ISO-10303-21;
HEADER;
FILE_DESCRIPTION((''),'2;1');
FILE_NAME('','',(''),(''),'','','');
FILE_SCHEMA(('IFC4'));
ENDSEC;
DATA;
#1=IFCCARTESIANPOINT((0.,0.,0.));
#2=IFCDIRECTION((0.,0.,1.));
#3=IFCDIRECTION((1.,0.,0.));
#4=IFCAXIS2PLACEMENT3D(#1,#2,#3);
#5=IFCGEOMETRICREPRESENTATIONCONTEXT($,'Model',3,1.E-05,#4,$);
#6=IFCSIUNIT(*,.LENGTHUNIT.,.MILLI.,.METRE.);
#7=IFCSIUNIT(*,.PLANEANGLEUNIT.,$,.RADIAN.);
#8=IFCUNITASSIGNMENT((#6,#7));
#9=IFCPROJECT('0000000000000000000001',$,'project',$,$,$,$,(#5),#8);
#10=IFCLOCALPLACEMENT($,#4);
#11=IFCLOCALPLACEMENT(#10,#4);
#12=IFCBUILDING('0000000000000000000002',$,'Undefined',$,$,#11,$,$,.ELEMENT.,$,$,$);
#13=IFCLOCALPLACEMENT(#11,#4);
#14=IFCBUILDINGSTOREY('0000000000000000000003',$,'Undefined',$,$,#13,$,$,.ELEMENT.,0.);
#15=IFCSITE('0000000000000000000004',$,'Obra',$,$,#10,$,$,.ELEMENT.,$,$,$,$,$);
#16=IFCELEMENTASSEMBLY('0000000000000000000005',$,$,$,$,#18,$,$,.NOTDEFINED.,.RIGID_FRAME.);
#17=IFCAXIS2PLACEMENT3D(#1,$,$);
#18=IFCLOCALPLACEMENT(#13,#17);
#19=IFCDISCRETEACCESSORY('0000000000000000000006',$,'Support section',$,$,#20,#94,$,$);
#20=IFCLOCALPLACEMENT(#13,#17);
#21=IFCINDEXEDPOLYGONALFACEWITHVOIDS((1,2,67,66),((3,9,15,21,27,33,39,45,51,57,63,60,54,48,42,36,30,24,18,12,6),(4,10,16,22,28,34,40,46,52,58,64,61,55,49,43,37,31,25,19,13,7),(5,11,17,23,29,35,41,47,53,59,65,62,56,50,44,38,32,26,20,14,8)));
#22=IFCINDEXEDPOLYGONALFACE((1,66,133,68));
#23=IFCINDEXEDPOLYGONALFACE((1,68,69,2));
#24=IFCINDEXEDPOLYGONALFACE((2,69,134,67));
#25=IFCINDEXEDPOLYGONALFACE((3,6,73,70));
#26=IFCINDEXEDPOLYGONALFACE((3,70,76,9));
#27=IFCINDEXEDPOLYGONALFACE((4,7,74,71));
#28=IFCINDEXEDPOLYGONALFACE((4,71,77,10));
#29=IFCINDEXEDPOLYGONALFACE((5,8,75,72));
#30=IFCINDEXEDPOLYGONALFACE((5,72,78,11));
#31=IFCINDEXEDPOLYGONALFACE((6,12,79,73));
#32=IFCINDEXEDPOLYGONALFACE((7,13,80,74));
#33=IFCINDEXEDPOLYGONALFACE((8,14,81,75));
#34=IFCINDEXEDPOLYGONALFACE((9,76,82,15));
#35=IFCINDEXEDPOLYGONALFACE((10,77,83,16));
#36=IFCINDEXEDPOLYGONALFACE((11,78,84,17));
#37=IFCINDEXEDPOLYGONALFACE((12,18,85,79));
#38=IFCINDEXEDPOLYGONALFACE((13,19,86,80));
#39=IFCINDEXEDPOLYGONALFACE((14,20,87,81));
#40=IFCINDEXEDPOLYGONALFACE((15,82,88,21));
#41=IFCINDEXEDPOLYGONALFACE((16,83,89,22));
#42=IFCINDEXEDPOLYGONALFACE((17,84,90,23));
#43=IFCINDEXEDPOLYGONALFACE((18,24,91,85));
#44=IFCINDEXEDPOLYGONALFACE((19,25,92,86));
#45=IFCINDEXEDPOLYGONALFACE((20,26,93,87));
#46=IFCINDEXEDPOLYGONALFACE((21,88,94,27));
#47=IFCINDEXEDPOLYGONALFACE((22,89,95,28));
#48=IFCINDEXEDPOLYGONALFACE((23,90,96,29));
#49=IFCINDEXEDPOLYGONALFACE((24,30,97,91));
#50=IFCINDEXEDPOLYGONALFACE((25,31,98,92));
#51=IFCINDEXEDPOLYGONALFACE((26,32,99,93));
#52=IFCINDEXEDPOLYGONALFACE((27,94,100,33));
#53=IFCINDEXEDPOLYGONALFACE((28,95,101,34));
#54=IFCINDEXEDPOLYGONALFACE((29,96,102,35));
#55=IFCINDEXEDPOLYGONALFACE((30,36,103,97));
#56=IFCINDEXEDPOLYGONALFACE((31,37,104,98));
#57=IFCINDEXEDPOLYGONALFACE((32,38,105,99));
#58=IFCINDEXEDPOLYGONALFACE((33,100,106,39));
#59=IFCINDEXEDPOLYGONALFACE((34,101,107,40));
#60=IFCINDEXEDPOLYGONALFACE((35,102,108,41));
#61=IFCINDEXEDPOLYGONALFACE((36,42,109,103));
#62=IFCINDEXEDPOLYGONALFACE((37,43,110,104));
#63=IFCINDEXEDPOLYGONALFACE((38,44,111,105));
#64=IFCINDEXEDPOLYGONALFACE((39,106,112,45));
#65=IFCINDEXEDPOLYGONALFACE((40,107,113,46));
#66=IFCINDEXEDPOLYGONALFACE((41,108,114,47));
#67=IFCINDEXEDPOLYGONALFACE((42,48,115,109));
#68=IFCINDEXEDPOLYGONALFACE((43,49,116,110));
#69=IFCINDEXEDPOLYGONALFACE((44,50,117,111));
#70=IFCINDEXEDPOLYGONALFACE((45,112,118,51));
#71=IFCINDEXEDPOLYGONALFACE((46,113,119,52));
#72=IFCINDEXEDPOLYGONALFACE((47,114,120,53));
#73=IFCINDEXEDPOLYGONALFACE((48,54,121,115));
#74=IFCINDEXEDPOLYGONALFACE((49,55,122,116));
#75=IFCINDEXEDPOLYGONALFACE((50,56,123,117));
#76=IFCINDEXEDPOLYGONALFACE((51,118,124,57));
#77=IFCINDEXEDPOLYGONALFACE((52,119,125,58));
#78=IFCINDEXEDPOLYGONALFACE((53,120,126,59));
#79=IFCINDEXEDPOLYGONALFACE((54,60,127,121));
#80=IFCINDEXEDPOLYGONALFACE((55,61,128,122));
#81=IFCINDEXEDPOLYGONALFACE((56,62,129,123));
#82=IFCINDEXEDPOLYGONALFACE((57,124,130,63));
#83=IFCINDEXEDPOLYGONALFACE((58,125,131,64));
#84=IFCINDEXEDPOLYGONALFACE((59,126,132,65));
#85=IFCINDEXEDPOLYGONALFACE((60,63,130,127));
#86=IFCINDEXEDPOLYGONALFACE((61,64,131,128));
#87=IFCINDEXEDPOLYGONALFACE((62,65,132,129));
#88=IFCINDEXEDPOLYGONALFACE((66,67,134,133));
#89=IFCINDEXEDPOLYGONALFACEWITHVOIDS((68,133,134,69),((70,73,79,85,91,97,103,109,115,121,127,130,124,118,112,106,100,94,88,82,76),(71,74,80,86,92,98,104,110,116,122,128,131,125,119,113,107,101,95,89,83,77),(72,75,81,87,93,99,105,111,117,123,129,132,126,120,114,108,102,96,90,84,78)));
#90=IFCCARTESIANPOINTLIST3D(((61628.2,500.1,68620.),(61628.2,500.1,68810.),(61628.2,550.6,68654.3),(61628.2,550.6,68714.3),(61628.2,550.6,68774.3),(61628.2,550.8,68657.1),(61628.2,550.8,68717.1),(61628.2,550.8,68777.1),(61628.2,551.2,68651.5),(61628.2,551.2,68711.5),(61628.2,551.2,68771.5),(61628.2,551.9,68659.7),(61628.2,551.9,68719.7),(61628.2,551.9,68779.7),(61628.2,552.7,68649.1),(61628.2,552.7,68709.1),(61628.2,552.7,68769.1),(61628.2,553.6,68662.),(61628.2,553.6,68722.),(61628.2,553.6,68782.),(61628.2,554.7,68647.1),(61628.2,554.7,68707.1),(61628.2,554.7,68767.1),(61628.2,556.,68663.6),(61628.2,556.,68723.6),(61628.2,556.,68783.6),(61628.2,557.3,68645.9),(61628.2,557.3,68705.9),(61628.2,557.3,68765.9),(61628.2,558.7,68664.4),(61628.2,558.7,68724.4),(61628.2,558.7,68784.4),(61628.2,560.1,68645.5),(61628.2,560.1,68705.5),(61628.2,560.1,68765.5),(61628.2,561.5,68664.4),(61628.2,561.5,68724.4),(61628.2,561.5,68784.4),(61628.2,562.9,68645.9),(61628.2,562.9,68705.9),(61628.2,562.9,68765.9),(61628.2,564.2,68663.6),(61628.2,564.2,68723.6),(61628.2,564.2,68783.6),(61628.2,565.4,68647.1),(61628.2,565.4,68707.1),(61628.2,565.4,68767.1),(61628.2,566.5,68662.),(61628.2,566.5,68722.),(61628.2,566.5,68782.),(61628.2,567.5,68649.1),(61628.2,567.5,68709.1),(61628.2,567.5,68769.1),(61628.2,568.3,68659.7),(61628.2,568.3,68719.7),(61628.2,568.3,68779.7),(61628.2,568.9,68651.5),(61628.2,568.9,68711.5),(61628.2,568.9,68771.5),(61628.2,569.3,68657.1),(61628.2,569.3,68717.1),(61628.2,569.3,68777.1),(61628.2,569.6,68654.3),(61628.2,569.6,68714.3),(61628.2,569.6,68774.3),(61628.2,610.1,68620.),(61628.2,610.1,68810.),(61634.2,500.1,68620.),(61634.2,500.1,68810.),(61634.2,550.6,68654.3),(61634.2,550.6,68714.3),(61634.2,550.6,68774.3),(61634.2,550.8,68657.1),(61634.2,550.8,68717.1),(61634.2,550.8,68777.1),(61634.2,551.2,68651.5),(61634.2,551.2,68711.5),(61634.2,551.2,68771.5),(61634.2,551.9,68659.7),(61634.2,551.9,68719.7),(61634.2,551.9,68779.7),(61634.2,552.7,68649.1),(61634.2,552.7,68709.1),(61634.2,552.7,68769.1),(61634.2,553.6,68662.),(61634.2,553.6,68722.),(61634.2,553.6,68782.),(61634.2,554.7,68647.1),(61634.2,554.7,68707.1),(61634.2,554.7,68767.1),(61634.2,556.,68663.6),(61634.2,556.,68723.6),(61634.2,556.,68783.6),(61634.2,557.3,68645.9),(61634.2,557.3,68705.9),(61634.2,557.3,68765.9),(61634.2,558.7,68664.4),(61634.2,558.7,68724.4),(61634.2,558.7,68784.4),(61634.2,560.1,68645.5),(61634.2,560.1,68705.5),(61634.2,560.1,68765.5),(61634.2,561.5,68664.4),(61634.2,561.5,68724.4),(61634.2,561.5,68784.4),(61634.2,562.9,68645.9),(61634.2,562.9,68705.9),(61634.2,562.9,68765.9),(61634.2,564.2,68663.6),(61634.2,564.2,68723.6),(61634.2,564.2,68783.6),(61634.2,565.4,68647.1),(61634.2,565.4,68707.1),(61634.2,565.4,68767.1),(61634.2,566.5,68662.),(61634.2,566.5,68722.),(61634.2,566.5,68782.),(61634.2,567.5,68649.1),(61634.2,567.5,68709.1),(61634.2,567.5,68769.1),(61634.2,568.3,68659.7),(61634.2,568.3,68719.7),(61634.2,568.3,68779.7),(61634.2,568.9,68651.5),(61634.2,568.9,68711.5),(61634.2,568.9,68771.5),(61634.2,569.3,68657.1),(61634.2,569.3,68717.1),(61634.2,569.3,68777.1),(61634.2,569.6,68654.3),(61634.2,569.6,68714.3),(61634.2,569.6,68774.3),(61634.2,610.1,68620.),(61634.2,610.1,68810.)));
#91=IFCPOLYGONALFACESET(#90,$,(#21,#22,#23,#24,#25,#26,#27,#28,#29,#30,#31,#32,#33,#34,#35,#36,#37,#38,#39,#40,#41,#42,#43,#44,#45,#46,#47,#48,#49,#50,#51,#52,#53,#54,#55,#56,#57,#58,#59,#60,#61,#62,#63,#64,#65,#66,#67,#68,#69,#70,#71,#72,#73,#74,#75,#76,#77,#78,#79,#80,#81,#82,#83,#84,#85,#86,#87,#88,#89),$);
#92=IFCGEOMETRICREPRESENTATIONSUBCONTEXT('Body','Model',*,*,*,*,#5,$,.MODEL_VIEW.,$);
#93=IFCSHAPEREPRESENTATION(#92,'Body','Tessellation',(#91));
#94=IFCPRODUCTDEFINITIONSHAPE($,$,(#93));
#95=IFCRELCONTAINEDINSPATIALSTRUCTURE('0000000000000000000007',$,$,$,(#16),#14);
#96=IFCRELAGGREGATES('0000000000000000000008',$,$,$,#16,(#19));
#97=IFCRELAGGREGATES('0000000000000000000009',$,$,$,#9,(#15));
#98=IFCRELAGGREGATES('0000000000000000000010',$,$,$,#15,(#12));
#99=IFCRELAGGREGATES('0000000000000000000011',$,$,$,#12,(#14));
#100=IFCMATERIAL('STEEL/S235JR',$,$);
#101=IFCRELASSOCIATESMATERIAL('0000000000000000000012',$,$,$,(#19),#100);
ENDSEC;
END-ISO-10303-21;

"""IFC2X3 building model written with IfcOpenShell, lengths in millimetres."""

from ifc_helpers import new_model, si_unit, frame, origin_with_axes, origin_2d_with_axis, place, context, subcontext, project, spatial, rectangle, circle, extrude, source, transform, mapped, material, element, aggregate, save


model = new_model("IFC2X3")

# Units and contexts
model_context = context("Model", 3, precision=1e-05, world=origin_with_axes())
body_context = subcontext(model_context, "Body", "Model", "MODEL_VIEW")
ifc_project = project(units=[si_unit("LENGTHUNIT", "METRE", prefix="MILLI"), si_unit("PLANEANGLEUNIT", "RADIAN")], contexts=[model_context])

# Site, building, storey
site_placement = place(None, origin_with_axes())
site = spatial("IfcSite", under=ifc_project, at=site_placement, Name="Obra", CompositionType="ELEMENT")
building_placement = place(site_placement, origin_with_axes())
building = spatial("IfcBuilding", under=site, at=building_placement, Name="Undefined", CompositionType="ELEMENT")
storey_placement = place(building_placement, origin_with_axes())
storey = spatial("IfcBuildingStorey", under=building, at=storey_placement, Name="Undefined", CompositionType="ELEMENT", Elevation=0.0)

# Element assembly
ifc_material = material(Name="STEEL/S235JR")
assembly_1_placement = place(storey_placement, origin_with_axes())
assembly_1 = element("IfcElementAssembly", 1, at=assembly_1_placement, inside=storey, AssemblyPlace="NOTDEFINED", PredefinedType="RIGID_FRAME")

# Discrete accessory, opening
shared_shape_1 = source(origin_with_axes(), body_context, "Body", "SweptSolid", [
    extrude(circle(Radius=9.5, at=origin_2d_with_axis()), frame((0.0, -9.2, 0.0), z_axis=(0.0, 1.0, 0.0), x_axis=(1.0, 0.0, 0.0)), (0.0, 0.0, 1.0), 6.2),
])
discrete_accessory_1_placement = place(assembly_1_placement, frame((61631.2, 555.1, 68620.0), z_axis=(0.0, 0.0, 1.0), x_axis=(0.000002, -1.0, 0.0)))
discrete_accessory_1 = element("IfcDiscreteAccessory", 2, at=discrete_accessory_1_placement, material=ifc_material, Name="Support section", context=body_context, shape_type="SweptSolid", body=[
    extrude(rectangle(XDim=6.0, YDim=110.0, at=origin_2d_with_axis()), frame((0.0, 0.0, 190.0), z_axis=(0.0, 0.0, -1.0), x_axis=(0.0, 1.0, 0.0)), (0.0, 0.0, 1.0), 190.0),
])
opening_1_placement = place(assembly_1_placement, frame((61625.1, 510.1, 68835.0), z_axis=(-0.000002, 1.0, 0.0), x_axis=(0.0, 0.0, -1.0)))
element("IfcOpeningElement", 3, at=opening_1_placement, cuts=discrete_accessory_1, ObjectType="Opening", context=body_context, shape_type="MappedRepresentation", body=[
    mapped(shared_shape_1, transform((60.0, 0.0, 50.0))),
    mapped(shared_shape_1, transform((120.0, 0.0, 50.0))),
    mapped(shared_shape_1, transform((180.0, 0.0, 50.0))),
])
aggregate(assembly_1, [discrete_accessory_1])

save(model, "model.ifc")
